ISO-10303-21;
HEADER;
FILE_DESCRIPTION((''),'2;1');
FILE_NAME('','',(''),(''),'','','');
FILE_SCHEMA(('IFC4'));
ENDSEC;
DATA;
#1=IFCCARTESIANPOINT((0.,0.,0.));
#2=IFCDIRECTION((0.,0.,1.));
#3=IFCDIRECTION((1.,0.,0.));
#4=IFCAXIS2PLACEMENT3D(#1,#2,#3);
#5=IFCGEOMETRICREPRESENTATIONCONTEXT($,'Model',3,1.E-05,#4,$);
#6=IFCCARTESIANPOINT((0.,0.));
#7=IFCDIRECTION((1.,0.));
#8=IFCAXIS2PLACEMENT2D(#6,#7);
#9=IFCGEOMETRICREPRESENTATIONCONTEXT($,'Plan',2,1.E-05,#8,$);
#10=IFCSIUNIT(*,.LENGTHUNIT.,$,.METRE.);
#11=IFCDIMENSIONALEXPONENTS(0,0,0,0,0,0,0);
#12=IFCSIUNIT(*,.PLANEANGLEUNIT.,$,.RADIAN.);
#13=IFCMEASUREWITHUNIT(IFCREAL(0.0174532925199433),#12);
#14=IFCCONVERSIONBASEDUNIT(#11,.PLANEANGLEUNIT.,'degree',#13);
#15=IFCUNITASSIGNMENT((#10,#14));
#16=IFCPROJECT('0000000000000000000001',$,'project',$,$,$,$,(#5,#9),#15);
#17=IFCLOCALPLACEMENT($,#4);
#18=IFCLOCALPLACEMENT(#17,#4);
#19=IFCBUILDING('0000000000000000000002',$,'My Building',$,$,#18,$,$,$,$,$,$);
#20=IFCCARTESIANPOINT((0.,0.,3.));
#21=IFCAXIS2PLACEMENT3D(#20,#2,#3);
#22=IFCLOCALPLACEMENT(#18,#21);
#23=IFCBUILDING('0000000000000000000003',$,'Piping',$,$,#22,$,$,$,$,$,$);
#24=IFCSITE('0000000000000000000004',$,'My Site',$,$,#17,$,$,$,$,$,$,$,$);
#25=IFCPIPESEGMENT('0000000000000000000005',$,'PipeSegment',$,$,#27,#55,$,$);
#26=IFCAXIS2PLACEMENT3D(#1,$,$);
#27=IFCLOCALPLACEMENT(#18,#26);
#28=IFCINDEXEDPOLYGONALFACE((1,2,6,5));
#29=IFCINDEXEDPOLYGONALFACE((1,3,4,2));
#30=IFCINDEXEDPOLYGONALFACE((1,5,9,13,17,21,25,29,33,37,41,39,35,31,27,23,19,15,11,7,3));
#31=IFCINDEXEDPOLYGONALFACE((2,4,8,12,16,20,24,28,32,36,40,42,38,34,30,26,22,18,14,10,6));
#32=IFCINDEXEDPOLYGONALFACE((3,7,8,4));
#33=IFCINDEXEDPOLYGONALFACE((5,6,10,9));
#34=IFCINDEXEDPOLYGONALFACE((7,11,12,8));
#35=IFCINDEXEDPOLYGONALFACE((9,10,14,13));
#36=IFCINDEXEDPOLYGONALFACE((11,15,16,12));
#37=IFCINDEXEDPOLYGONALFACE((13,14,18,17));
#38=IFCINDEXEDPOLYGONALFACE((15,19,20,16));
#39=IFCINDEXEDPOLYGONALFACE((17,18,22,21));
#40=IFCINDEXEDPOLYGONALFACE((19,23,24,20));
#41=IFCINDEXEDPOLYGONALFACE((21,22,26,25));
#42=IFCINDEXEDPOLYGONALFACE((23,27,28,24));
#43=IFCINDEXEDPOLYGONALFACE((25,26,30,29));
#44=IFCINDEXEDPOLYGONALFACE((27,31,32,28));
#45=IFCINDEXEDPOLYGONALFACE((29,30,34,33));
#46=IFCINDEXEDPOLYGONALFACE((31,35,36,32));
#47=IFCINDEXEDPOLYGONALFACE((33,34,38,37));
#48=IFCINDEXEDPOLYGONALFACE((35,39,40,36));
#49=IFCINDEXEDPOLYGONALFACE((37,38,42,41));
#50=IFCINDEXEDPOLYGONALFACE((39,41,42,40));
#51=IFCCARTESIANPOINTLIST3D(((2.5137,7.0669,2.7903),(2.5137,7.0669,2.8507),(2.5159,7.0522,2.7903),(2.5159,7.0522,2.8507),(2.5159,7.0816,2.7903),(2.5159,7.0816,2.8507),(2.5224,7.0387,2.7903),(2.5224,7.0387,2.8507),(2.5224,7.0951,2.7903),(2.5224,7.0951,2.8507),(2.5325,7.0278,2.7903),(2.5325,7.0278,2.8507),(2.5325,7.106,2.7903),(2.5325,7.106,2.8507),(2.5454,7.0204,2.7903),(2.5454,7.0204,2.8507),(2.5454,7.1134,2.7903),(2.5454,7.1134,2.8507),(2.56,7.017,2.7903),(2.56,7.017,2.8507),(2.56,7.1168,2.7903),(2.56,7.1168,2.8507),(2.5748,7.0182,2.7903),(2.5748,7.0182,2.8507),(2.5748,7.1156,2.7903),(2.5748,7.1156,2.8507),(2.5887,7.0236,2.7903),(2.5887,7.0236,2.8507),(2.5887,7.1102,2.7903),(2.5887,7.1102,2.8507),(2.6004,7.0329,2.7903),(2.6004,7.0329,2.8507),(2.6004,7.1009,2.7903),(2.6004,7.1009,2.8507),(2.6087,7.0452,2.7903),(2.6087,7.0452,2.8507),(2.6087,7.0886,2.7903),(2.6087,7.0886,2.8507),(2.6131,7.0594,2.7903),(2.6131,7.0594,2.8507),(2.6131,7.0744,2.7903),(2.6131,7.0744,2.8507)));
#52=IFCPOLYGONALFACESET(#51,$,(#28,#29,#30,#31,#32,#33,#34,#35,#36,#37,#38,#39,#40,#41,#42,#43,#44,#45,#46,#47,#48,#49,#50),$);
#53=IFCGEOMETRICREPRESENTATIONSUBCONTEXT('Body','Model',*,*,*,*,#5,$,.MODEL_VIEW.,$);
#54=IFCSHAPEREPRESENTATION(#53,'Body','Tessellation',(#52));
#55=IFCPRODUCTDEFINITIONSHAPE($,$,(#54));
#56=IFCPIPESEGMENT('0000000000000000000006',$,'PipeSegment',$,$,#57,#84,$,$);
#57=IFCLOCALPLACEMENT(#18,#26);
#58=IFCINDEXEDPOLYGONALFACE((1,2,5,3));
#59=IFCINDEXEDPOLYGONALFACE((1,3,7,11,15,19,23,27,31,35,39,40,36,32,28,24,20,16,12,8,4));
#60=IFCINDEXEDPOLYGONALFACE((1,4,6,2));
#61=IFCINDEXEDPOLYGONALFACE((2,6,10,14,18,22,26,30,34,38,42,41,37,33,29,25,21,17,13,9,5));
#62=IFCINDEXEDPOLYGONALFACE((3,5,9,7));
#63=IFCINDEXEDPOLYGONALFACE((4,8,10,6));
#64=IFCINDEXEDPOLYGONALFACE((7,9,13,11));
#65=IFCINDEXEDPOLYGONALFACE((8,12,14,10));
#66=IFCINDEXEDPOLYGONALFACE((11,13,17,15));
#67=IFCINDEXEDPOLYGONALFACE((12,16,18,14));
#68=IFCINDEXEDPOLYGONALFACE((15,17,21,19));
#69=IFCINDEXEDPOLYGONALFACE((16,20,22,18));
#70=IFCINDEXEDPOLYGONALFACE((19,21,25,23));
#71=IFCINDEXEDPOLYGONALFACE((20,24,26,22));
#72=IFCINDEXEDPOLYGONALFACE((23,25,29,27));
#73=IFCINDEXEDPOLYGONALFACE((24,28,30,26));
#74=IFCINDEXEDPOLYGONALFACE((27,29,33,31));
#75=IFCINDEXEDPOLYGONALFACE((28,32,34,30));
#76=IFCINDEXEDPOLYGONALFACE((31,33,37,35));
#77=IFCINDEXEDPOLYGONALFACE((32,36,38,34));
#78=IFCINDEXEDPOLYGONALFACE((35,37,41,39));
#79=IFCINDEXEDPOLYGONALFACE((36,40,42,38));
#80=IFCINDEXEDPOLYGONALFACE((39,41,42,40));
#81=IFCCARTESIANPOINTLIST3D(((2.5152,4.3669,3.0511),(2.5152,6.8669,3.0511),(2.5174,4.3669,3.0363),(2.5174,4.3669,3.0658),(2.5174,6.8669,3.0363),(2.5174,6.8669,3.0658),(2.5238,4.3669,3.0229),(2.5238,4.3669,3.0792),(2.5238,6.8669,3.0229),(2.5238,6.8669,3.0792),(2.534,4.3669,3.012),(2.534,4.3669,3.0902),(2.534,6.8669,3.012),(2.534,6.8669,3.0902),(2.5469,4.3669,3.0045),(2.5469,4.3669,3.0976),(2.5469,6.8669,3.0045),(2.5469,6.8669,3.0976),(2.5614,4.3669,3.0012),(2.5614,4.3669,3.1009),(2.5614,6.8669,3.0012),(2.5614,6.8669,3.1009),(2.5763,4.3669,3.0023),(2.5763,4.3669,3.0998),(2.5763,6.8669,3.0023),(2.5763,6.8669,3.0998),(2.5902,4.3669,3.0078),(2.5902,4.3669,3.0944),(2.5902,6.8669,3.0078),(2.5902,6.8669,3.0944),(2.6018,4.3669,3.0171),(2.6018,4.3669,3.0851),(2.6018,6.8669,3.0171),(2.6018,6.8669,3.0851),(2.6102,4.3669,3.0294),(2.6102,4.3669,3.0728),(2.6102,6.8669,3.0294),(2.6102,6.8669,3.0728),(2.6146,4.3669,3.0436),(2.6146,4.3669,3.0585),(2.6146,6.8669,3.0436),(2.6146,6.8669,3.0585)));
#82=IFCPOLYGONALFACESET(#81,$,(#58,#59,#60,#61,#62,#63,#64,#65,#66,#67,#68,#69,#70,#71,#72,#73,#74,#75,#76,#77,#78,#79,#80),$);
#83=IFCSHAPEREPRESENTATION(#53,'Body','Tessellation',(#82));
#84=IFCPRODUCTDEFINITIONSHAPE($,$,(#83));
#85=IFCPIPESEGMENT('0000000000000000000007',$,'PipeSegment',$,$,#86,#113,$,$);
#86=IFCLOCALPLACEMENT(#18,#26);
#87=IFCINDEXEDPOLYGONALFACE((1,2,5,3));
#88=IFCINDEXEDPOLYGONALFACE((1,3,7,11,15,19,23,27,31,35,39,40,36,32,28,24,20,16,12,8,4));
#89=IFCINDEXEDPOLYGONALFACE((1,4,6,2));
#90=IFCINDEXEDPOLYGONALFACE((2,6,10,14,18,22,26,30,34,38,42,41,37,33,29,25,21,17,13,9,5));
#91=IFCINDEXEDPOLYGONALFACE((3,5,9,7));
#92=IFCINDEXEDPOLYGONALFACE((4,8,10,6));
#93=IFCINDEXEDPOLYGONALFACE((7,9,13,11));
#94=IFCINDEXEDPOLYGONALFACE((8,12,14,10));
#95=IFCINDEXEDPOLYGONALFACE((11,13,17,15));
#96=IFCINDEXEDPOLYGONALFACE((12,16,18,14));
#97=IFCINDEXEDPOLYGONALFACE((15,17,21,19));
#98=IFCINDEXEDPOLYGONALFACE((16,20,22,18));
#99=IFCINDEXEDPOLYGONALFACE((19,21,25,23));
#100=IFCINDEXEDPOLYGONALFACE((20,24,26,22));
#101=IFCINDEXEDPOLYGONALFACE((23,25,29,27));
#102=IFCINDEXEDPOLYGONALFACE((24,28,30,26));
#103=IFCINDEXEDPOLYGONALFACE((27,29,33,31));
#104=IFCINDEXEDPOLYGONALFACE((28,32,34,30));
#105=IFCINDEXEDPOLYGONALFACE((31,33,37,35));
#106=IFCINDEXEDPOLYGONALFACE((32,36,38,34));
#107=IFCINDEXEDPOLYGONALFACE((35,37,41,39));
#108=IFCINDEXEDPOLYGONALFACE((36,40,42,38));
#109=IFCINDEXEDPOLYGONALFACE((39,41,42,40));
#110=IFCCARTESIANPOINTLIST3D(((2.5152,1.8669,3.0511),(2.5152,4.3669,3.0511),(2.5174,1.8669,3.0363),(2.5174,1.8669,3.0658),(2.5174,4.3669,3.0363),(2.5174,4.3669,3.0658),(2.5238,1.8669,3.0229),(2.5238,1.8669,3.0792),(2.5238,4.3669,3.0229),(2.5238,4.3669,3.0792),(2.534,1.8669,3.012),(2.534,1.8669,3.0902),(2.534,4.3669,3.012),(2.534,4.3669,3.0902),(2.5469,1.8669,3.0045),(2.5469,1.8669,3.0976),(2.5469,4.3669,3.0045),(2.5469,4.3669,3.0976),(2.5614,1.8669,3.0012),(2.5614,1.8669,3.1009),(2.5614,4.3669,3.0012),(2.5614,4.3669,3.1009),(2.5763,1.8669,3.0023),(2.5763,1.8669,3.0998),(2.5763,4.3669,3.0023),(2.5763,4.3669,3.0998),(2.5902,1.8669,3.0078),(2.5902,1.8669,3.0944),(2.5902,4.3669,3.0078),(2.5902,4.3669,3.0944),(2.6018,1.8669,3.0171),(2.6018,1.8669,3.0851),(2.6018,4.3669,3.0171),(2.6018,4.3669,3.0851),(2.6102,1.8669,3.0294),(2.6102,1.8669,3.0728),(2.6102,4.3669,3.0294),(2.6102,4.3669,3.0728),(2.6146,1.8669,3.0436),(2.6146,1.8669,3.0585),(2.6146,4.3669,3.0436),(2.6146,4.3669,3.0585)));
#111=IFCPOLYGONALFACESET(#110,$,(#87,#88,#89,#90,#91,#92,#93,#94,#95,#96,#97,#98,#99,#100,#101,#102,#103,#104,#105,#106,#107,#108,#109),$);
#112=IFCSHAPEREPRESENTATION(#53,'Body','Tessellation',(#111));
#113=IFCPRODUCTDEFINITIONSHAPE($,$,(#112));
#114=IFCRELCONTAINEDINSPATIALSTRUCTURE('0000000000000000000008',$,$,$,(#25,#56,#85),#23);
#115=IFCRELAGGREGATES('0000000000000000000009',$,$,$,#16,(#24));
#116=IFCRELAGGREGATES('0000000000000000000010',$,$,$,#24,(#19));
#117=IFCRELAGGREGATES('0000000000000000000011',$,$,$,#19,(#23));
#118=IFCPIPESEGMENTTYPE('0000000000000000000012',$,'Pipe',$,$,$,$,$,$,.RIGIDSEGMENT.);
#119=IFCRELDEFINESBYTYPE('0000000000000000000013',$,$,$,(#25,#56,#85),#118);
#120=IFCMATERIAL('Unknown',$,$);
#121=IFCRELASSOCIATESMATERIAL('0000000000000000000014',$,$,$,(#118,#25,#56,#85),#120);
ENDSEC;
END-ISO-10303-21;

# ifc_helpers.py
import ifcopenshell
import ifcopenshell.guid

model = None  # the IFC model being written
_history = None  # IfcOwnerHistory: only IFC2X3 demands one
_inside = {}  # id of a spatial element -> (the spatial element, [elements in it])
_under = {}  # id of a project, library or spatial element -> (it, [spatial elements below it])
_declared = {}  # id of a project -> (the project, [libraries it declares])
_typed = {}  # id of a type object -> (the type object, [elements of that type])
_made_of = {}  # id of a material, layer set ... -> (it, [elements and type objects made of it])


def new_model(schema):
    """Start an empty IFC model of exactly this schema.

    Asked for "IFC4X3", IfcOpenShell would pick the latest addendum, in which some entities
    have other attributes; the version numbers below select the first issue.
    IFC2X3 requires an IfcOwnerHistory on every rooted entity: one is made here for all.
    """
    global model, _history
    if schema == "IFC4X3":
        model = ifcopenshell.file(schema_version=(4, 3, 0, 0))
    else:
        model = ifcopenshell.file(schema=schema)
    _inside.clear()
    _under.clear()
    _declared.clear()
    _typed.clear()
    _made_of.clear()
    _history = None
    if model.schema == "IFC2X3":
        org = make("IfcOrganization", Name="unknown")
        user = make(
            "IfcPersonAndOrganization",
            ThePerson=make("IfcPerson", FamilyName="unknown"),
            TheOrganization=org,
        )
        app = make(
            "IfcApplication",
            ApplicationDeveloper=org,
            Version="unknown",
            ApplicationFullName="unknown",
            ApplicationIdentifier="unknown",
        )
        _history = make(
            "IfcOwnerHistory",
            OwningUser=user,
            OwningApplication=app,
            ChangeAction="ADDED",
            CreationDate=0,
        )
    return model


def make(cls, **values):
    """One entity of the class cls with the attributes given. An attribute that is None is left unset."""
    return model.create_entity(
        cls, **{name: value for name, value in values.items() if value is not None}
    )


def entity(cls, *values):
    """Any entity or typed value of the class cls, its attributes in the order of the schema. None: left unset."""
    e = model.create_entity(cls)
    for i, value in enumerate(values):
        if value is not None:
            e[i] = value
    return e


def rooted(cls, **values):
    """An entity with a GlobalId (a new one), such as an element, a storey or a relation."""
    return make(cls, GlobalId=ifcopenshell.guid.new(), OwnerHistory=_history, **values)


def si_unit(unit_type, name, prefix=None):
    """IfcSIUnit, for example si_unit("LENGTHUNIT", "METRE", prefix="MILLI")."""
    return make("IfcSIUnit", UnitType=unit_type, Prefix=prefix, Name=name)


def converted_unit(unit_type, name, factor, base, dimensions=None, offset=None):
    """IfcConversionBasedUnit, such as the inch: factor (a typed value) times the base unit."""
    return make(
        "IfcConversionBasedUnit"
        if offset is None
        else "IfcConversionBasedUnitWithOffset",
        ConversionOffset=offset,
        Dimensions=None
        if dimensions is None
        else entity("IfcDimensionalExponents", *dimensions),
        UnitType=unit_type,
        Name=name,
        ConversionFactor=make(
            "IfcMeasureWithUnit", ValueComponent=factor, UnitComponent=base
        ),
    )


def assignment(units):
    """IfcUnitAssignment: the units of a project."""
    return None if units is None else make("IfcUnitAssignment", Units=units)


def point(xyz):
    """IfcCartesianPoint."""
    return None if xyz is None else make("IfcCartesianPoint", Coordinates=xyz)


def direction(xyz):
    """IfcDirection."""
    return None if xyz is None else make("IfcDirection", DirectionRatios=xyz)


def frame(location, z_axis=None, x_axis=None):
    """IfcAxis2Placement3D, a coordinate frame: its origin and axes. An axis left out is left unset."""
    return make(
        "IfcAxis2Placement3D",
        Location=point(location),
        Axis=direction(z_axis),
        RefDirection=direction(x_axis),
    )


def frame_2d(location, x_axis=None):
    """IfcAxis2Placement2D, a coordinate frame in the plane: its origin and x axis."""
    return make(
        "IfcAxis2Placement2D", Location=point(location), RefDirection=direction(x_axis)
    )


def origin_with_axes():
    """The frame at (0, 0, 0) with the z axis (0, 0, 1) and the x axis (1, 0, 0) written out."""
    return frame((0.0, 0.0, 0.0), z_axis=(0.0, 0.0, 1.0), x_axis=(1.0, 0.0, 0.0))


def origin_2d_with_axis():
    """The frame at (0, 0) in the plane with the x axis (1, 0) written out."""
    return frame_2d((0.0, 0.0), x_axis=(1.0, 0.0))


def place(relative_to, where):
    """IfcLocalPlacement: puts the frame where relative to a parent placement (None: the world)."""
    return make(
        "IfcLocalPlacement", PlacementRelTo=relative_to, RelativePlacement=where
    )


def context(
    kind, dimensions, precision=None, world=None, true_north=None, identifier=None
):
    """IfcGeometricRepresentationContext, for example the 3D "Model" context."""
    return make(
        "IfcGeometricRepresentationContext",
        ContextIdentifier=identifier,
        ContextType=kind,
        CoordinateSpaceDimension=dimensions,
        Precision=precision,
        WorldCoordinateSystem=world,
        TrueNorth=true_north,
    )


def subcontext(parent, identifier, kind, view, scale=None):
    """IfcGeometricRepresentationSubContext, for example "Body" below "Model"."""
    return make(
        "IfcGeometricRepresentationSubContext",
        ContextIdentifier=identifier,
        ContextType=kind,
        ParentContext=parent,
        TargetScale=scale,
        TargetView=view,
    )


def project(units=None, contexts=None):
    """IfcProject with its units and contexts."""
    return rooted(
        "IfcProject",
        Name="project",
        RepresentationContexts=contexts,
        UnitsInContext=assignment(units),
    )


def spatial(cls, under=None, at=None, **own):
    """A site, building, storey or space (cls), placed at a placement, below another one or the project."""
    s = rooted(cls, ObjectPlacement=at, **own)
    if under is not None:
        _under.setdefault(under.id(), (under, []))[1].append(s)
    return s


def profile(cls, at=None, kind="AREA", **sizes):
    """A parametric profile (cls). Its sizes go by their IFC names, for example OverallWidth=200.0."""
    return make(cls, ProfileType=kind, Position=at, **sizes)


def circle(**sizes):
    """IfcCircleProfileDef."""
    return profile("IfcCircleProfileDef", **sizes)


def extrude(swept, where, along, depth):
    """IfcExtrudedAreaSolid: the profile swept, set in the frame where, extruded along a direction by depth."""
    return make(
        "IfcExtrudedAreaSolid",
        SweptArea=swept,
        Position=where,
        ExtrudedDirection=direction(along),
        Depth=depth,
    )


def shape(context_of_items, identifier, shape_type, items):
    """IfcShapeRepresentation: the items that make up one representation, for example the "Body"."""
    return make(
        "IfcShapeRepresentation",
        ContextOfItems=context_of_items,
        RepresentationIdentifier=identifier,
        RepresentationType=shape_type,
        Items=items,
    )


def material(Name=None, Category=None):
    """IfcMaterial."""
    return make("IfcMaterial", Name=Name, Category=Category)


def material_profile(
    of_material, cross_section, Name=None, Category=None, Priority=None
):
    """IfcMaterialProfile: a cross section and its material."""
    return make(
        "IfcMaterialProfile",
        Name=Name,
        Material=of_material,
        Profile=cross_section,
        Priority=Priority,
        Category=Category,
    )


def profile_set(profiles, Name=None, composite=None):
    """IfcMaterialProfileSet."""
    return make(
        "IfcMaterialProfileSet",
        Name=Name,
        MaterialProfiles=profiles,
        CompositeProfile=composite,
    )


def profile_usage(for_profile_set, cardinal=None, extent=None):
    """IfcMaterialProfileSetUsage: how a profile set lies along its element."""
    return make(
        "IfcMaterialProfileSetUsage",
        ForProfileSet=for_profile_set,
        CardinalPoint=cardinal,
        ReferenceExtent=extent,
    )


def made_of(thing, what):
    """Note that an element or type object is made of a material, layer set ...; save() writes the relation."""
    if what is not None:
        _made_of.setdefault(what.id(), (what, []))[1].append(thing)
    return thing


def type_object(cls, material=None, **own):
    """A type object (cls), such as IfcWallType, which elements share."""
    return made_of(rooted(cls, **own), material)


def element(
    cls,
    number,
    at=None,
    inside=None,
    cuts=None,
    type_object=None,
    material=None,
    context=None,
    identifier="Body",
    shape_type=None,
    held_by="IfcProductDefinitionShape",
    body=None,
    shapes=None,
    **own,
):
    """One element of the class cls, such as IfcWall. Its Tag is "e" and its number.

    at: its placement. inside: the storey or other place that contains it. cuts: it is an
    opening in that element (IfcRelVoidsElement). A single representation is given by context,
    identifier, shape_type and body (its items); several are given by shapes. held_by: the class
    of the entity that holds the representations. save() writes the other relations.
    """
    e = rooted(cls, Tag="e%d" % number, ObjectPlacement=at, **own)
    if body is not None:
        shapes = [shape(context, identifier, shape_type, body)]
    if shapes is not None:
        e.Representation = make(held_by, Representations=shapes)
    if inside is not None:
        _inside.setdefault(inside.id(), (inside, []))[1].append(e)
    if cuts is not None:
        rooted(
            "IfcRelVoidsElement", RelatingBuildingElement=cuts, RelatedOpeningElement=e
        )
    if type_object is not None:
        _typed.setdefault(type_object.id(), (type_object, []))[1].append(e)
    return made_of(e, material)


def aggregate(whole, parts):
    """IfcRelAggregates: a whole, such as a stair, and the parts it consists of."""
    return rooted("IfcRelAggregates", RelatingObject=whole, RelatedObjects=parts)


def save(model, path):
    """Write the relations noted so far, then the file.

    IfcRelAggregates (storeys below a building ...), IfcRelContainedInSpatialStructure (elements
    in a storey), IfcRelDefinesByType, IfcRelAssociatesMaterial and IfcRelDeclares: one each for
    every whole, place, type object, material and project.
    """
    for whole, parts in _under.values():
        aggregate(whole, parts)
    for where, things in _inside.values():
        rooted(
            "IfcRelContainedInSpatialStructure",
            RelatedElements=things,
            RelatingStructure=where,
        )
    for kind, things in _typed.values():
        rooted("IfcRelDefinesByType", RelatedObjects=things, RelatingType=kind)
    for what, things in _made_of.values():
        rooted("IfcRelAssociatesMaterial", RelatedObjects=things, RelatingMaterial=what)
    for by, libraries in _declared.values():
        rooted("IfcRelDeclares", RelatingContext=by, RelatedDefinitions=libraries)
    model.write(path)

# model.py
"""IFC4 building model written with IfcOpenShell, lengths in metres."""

from ifc_helpers import new_model, entity, si_unit, converted_unit, frame, origin_with_axes, origin_2d_with_axis, place, context, subcontext, project, spatial, circle, extrude, material, material_profile, profile_set, profile_usage, type_object, element, save


model = new_model("IFC4")

# Units and contexts
model_context = context("Model", 3, precision=1e-05, world=origin_with_axes())
plan_context = context("Plan", 2, precision=1e-05, world=origin_2d_with_axis())
body_context = subcontext(model_context, "Body", "Model", "MODEL_VIEW")
ifc_project = project(units=[si_unit("LENGTHUNIT", "METRE"), converted_unit("PLANEANGLEUNIT", "degree", entity("IfcReal", 0.0174532925199433), si_unit("PLANEANGLEUNIT", "RADIAN"), dimensions=[0, 0, 0, 0, 0, 0, 0])], contexts=[model_context, plan_context])

# Site, buildings
site_placement = place(None, origin_with_axes())
site = spatial("IfcSite", under=ifc_project, at=site_placement, Name="My Site")
building_1_placement = place(site_placement, origin_with_axes())
building_1 = spatial("IfcBuilding", under=site, at=building_1_placement, Name="My Building")
building_2_placement = place(building_1_placement, frame((0.0, 0.0, 3.0), z_axis=(0.0, 0.0, 1.0), x_axis=(1.0, 0.0, 0.0)))
building_2 = spatial("IfcBuilding", under=building_1, at=building_2_placement, Name="Piping")

# Pipe segments
ifc_material = material(Name="Unknown")
ifc_material_profile_1 = material_profile(ifc_material, circle(Radius=0.05))
ifc_profile_set_1 = profile_set([ifc_material_profile_1])
pipe_segment_type = type_object("IfcPipeSegmentType", Name="Pipe", PredefinedType="RIGIDSEGMENT", material=ifc_profile_set_1)
ifc_profile_usage_1 = profile_usage(ifc_profile_set_1, cardinal=5)
pipe_segment_1_placement = place(building_2_placement, frame((2.5637, 7.0669, -0.1493), z_axis=(0.0, 0.0, -1.0), x_axis=(-1.0, 0.0, 0.0)))
element("IfcPipeSegment", 1, at=pipe_segment_1_placement, inside=building_2, type_object=pipe_segment_type, material=ifc_profile_usage_1, Name="PipeSegment", context=body_context, shape_type="SweptSolid", body=[
    extrude(circle(Radius=0.05), origin_with_axes(), (0.0, 0.0, 1.0), 0.0604),
])
ifc_profile_usage_2 = profile_usage(ifc_profile_set_1, cardinal=5)
pipe_segment_2_placement = place(building_2_placement, frame((2.5652, 4.3669, 0.0511), z_axis=(0.0, 1.0, 0.0), x_axis=(-1.0, 0.0, 0.0)))
element("IfcPipeSegment", 2, at=pipe_segment_2_placement, inside=building_2, type_object=pipe_segment_type, material=ifc_profile_usage_2, Name="PipeSegment", context=body_context, shape_type="SweptSolid", body=[
    extrude(circle(Radius=0.05), origin_with_axes(), (0.0, 0.0, 1.0), 2.5),
])
ifc_profile_usage_3 = profile_usage(ifc_profile_set_1, cardinal=5)
pipe_segment_3_placement = place(building_2_placement, frame((2.5652, 1.8669, 0.0511), z_axis=(0.0, 1.0, 0.0), x_axis=(-1.0, 0.0, 0.0)))
element("IfcPipeSegment", 3, at=pipe_segment_3_placement, inside=building_2, type_object=pipe_segment_type, material=ifc_profile_usage_3, Name="PipeSegment", context=body_context, shape_type="SweptSolid", body=[
    extrude(circle(Radius=0.05), origin_with_axes(), (0.0, 0.0, 1.0), 2.5),
])

save(model, "model.ifc")
